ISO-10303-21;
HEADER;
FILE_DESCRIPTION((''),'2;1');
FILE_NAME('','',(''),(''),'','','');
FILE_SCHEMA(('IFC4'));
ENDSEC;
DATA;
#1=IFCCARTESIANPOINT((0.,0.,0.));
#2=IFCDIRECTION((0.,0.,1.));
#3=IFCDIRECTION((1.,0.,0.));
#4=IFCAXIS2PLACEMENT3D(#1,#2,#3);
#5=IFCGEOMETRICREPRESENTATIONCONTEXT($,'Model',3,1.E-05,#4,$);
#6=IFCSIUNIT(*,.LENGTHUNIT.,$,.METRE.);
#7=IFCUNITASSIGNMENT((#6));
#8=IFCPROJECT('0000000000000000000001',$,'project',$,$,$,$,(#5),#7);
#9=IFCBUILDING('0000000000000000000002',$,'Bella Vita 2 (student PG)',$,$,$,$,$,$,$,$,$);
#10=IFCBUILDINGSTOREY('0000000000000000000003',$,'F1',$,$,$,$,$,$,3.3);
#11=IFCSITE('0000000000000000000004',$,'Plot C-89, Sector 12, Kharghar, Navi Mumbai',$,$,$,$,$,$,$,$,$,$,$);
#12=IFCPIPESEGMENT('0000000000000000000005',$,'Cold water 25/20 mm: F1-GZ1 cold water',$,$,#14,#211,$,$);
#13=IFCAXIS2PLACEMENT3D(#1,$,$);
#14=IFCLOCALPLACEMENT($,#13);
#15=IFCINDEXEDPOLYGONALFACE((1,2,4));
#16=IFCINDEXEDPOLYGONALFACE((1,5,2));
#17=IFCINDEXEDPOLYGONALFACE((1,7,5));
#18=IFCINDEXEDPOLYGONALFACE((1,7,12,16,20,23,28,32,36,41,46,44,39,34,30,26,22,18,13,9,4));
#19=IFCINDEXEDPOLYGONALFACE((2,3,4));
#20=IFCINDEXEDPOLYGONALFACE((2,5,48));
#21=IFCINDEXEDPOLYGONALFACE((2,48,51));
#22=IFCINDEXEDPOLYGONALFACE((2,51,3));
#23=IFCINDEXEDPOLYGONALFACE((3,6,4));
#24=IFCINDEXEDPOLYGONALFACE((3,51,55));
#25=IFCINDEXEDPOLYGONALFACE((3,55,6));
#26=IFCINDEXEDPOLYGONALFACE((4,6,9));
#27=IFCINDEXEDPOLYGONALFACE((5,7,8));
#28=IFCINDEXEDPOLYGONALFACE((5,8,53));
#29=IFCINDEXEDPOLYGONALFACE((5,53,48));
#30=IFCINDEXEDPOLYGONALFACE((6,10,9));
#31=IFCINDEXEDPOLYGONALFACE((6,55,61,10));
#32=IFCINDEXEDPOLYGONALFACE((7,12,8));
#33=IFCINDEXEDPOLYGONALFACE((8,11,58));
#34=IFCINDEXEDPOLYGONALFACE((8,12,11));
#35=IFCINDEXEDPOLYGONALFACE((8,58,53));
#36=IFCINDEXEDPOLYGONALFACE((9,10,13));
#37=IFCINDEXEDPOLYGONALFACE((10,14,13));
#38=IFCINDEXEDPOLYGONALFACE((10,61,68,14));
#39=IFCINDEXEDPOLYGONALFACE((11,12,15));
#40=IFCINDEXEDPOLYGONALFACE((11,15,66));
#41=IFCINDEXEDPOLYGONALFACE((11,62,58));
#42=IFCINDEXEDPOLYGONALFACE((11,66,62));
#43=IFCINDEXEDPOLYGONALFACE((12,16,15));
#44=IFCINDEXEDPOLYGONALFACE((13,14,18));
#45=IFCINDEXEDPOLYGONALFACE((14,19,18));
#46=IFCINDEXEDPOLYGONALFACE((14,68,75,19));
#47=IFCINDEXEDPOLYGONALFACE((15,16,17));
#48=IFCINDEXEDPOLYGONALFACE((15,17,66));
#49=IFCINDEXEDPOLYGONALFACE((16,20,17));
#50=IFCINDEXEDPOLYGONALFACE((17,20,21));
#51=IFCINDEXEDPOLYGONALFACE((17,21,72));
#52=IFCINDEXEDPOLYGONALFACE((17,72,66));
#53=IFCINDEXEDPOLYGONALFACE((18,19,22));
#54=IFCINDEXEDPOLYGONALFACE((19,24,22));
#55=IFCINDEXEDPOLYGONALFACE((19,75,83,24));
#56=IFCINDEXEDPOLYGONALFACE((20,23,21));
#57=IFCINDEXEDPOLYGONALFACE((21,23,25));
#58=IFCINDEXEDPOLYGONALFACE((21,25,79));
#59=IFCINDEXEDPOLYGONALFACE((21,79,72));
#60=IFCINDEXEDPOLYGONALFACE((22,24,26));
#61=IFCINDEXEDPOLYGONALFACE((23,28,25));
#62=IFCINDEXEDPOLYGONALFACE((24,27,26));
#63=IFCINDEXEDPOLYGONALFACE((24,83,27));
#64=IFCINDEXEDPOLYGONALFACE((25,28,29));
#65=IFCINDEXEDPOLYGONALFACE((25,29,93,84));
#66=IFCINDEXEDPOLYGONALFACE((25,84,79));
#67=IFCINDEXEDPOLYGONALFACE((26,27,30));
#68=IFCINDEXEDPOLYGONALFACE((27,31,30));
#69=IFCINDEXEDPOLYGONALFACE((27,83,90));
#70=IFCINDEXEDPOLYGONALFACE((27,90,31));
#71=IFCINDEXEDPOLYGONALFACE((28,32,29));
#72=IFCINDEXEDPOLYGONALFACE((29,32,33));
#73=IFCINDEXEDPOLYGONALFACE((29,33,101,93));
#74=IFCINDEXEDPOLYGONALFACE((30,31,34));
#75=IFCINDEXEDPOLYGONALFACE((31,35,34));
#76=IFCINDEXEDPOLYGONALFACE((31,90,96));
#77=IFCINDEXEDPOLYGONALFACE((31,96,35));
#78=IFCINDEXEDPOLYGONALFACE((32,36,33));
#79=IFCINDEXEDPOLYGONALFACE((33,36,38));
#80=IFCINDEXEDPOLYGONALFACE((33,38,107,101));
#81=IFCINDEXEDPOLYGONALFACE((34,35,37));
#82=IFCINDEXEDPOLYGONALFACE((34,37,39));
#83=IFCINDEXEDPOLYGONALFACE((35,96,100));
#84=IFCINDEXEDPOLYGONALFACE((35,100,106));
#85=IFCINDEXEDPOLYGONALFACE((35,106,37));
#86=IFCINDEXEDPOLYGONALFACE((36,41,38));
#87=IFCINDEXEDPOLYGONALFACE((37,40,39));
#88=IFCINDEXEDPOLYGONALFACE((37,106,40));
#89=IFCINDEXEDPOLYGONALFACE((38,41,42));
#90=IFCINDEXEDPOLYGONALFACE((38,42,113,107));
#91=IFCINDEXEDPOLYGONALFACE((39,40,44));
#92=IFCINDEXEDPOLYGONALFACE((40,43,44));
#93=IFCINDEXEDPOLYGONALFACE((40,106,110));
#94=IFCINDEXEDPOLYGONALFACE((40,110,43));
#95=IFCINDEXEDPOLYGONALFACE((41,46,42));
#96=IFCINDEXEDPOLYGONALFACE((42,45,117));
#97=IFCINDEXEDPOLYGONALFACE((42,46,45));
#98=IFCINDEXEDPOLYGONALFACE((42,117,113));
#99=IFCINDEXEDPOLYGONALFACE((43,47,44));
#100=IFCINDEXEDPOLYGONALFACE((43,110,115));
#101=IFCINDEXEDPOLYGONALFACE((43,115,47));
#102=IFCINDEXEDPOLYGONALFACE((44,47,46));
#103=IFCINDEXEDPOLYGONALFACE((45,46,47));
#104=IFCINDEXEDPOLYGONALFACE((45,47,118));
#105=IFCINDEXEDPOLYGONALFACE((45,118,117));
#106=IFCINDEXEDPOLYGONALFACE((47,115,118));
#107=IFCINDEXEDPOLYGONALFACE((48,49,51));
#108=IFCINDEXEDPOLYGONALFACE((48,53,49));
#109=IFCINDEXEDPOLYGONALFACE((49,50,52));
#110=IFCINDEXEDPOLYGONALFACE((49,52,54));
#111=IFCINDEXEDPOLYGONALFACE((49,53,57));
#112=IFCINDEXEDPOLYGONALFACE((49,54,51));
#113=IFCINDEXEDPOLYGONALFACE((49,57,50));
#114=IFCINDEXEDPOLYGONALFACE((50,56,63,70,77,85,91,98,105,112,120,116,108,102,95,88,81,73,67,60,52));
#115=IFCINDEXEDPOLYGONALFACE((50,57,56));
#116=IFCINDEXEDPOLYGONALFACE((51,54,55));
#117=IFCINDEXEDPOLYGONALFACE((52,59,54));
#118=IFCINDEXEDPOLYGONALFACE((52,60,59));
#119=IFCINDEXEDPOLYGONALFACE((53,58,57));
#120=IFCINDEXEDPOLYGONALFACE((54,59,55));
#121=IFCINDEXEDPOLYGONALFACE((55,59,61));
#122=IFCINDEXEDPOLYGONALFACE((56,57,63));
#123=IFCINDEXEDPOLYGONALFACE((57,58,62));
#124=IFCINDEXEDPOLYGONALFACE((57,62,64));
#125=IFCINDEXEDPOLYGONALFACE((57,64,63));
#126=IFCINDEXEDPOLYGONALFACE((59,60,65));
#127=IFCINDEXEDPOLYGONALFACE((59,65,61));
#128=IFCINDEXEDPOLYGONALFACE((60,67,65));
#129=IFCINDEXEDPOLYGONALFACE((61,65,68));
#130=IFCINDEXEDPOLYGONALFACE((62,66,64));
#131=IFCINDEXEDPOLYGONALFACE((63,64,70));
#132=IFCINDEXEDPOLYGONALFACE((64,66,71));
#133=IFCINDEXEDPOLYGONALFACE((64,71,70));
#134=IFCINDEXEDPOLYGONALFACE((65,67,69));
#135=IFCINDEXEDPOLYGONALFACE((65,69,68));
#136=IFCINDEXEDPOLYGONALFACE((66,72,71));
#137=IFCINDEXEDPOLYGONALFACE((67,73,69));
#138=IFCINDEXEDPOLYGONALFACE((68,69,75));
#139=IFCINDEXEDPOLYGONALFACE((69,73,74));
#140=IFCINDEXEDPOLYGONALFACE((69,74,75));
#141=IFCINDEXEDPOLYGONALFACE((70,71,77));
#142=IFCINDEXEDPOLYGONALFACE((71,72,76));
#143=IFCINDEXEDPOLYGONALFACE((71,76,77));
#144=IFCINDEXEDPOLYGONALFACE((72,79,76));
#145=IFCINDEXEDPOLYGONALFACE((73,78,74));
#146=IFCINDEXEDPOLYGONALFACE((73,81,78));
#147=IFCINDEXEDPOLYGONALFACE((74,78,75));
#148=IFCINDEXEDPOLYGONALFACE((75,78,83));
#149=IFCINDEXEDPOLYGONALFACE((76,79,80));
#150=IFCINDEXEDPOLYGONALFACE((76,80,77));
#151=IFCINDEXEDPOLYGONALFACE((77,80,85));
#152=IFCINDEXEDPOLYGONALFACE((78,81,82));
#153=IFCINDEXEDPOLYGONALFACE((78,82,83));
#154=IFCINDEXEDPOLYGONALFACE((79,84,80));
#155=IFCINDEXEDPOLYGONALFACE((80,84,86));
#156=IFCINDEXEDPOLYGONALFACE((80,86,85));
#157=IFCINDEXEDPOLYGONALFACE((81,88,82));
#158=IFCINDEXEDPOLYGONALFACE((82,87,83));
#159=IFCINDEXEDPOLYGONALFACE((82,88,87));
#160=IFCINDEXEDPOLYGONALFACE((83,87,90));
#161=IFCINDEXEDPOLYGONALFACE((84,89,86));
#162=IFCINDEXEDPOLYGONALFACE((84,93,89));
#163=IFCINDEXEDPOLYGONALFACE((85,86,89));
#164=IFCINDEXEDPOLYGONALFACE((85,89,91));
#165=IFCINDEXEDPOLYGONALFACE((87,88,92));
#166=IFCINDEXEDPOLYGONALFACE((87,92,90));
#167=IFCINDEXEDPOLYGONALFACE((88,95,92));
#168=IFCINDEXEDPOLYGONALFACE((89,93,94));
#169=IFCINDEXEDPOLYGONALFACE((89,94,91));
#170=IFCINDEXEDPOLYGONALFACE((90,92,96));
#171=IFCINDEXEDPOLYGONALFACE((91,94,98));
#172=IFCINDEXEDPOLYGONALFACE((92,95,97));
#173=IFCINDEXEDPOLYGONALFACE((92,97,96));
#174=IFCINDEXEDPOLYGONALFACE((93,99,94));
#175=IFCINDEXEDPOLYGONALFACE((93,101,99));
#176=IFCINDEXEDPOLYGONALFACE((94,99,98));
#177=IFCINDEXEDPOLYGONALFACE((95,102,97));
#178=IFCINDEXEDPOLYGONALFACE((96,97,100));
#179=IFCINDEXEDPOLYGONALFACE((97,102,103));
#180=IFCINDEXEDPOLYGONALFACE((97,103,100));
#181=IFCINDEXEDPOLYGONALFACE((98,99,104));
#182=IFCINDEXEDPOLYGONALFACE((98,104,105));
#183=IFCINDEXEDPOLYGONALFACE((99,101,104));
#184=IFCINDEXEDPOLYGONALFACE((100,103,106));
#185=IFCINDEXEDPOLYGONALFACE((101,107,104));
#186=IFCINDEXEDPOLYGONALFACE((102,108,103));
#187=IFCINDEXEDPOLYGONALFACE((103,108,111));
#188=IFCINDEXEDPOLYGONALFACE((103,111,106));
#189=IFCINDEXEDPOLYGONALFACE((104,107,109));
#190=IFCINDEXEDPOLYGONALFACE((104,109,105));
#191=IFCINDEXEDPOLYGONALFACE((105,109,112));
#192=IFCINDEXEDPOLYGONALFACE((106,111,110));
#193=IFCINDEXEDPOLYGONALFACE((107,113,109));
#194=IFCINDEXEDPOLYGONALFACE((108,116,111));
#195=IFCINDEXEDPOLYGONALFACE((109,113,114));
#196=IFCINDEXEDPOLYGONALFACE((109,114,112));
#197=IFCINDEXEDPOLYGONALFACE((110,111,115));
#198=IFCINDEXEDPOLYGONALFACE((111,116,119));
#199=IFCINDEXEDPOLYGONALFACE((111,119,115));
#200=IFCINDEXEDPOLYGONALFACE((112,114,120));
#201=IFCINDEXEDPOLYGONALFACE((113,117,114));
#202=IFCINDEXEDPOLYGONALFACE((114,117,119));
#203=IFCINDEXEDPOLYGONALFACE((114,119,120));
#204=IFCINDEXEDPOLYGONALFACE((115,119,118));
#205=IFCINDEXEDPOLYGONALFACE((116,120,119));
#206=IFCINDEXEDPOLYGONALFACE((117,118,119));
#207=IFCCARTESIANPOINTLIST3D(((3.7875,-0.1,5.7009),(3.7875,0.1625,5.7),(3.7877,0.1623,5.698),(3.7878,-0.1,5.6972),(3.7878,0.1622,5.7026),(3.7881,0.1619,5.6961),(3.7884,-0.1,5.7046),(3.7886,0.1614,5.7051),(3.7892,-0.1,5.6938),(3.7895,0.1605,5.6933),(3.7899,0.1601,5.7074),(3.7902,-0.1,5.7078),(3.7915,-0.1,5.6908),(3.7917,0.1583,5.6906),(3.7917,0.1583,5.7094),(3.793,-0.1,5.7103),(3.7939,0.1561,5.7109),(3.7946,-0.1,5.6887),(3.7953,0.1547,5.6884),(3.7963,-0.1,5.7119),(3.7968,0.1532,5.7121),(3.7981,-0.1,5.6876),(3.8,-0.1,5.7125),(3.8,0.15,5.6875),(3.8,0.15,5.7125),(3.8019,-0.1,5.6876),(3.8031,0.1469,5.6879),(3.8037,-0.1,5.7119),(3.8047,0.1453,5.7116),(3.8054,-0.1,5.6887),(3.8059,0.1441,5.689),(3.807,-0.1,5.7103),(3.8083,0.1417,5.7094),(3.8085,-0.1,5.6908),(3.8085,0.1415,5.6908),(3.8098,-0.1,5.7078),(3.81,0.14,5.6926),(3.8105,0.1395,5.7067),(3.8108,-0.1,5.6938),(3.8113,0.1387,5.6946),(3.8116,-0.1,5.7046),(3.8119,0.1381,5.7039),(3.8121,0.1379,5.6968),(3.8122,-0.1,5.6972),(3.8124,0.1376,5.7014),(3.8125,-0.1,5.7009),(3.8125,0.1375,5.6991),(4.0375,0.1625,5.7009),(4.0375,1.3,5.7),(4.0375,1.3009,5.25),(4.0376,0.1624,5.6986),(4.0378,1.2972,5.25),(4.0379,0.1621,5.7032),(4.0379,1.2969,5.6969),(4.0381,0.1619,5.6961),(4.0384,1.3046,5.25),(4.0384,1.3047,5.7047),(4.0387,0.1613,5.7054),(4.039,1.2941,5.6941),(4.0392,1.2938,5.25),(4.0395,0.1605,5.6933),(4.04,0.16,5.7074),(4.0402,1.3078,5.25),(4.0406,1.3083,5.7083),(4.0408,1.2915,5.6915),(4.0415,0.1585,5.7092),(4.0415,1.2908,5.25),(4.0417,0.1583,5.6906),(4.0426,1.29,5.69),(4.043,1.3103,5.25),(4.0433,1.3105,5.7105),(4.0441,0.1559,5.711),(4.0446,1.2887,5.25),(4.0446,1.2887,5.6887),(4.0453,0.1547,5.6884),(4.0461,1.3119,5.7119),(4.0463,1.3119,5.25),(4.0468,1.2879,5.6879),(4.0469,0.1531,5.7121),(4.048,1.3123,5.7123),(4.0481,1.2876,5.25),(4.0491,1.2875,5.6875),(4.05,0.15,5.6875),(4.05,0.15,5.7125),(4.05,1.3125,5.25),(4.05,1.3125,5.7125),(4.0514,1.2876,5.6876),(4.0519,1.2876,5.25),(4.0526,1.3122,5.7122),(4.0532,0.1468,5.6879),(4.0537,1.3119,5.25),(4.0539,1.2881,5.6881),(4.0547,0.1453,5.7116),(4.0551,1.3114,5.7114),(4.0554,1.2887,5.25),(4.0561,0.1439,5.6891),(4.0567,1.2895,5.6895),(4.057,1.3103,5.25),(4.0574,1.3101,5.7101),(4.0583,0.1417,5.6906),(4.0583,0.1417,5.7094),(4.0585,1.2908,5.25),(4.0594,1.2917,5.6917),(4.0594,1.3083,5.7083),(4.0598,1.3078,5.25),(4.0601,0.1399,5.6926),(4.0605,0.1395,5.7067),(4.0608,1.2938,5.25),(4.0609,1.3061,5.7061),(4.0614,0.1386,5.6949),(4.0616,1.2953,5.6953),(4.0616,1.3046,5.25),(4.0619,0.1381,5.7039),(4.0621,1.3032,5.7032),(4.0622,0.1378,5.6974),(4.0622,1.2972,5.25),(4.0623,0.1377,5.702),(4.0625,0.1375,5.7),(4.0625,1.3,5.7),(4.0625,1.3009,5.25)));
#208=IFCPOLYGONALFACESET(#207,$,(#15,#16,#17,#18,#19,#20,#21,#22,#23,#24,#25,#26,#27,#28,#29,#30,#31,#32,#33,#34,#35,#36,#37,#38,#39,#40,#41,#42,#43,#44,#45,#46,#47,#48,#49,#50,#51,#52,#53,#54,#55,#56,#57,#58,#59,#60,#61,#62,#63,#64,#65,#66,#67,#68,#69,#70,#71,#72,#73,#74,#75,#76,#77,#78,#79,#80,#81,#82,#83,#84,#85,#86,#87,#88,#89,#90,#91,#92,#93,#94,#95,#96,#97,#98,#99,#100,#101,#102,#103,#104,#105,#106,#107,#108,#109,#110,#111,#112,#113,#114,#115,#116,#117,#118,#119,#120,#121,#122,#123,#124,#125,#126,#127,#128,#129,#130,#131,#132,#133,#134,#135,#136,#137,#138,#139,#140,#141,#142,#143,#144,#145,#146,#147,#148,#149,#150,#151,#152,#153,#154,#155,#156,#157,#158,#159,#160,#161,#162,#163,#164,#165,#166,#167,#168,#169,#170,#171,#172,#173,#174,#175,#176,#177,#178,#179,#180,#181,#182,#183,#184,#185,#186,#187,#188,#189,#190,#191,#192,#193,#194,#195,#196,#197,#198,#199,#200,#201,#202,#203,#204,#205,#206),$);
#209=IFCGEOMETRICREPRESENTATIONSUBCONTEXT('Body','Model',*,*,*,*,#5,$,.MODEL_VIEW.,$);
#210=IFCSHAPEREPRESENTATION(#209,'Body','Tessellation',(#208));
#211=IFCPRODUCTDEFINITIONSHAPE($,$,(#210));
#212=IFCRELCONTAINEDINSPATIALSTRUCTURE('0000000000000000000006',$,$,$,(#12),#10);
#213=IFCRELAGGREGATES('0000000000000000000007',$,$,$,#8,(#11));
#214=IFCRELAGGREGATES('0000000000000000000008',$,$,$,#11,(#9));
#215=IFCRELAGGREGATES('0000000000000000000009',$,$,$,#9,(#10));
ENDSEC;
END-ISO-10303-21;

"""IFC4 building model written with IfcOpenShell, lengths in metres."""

from ifc_helpers import new_model, entity, si_unit, origin, origin_with_axes, place, context, subcontext, project, spatial, element, save


model = new_model("IFC4")

# Units and contexts
model_context = context("Model", 3, precision=1e-05, world=origin_with_axes())
body_context = subcontext(model_context, "Body", "Model", "MODEL_VIEW")
ifc_project = project(units=[si_unit("LENGTHUNIT", "METRE")], contexts=[model_context])

# Site, building, storey
site = spatial("IfcSite", under=ifc_project, Name="Plot C-89, Sector 12, Kharghar, Navi Mumbai")
building = spatial("IfcBuilding", under=site, Name="Bella Vita 2 (student PG)")
storey = spatial("IfcBuildingStorey", under=building, Name="F1", Elevation=3.3)

# Pipe segment
pipe_segment_1_placement = place(None, origin())
element("IfcPipeSegment", 1, at=pipe_segment_1_placement, inside=storey, Name="Cold water 25/20 mm: F1-GZ1 cold water", context=body_context, shape_type="AdvancedSweptSolid", body=[
    entity("IfcSweptDiskSolid", entity("IfcPolyline", [entity("IfcCartesianPoint", [3.8, -0.1, 5.7]), entity("IfcCartesianPoint", [3.8, 0.15, 5.7]), entity("IfcCartesianPoint", [4.05, 0.15, 5.7]), entity("IfcCartesianPoint", [4.05, 1.3, 5.7]), entity("IfcCartesianPoint", [4.05, 1.3, 5.25])]), 0.0125),
])

save(model, "model.ifc")
